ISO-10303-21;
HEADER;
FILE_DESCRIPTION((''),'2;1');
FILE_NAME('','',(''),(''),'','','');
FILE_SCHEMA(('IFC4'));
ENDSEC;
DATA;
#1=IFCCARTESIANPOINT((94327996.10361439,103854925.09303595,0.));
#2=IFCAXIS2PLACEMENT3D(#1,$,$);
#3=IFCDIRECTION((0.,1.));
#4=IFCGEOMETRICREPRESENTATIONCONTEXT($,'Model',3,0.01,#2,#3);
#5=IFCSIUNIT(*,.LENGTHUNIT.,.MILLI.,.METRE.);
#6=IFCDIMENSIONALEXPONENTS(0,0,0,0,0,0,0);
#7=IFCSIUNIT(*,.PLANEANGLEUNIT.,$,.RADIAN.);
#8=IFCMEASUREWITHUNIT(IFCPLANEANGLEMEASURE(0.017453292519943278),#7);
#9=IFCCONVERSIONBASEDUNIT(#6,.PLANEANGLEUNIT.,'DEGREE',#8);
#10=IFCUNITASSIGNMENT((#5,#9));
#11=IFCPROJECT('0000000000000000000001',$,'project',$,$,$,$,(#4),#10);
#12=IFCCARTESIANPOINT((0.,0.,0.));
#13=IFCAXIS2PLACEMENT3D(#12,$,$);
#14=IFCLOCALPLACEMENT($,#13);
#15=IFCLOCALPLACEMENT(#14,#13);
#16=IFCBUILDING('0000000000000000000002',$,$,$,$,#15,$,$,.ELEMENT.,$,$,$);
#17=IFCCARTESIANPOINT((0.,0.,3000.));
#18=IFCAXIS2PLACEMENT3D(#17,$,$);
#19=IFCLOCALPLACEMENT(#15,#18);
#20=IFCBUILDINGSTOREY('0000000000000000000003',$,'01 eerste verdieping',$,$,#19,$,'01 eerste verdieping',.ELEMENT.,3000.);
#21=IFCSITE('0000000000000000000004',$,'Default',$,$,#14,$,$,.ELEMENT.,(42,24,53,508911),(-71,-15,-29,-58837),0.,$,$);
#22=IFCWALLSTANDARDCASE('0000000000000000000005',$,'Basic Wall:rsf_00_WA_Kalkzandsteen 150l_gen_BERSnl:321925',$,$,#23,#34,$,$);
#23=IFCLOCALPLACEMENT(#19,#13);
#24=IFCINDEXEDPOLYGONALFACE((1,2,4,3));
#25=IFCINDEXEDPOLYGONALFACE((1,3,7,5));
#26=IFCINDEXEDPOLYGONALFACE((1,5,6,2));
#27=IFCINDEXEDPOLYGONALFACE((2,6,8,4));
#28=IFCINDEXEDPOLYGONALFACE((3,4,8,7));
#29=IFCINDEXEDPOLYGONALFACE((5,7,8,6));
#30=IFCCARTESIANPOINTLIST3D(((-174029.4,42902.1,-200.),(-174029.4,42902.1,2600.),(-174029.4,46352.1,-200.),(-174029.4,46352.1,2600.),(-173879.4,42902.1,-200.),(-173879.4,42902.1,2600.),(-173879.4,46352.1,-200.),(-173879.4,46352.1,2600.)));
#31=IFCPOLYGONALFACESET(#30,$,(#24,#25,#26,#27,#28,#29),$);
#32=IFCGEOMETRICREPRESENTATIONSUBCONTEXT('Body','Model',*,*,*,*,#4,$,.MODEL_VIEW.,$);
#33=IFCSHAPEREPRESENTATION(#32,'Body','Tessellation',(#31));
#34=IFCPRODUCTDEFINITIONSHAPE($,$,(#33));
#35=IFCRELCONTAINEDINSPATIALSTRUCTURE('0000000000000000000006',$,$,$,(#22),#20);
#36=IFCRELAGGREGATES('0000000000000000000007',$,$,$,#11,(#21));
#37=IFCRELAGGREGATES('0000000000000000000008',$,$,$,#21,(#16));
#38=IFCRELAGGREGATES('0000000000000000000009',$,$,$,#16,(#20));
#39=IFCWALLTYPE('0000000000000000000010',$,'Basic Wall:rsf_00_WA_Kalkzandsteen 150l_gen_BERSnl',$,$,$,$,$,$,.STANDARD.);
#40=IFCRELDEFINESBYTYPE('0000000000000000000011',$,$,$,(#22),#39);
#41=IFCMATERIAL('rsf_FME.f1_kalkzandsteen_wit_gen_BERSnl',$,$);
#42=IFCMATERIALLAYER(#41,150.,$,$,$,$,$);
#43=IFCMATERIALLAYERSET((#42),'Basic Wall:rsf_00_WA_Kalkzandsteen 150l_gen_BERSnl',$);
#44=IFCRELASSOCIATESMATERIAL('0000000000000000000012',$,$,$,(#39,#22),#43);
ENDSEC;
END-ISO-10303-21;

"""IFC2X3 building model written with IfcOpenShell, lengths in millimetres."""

from ifc_helpers import new_model, entity, si_unit, converted_unit, direction, frame, frame_2d, origin, place, context, subcontext, project, spatial, polyline, rectangle, extrude, clip, bounded_halfspace, material, layer, layer_set, layer_usage, type_object, element, save


model = new_model("IFC2X3")

# Units and contexts
model_context = context("Model", 3, precision=0.01, world=frame((94327996.10361439, 103854925.09303595, 0.0)), true_north=direction((0.0, 1.0)))
body_context = subcontext(model_context, "Body", "Model", "MODEL_VIEW")
ifc_project = project(units=[si_unit("LENGTHUNIT", "METRE", prefix="MILLI"), converted_unit("PLANEANGLEUNIT", "DEGREE", entity("IfcPlaneAngleMeasure", 0.017453292519943278), si_unit("PLANEANGLEUNIT", "RADIAN"), dimensions=[0, 0, 0, 0, 0, 0, 0])], contexts=[model_context])

# Site, building, storey
site_placement = place(None, origin())
site = spatial("IfcSite", under=ifc_project, at=site_placement, Name="Default", CompositionType="ELEMENT", RefLatitude=(42, 24, 53, 508911), RefLongitude=(-71, -15, -29, -58837), RefElevation=0.0)
building_placement = place(site_placement, origin())
building = spatial("IfcBuilding", under=site, at=building_placement, CompositionType="ELEMENT")
storey_placement = place(building_placement, frame((0.0, 0.0, 3000.0)))
storey = spatial("IfcBuildingStorey", under=building, at=storey_placement, Name="01 eerste verdieping", LongName="01 eerste verdieping", CompositionType="ELEMENT", Elevation=3000.0)

# Shared definitions
ifc_material = material(Name="rsf_FME.f1_kalkzandsteen_wit_gen_BERSnl")
ifc_layer = layer(ifc_material, 150.0)
ifc_layer_set = layer_set([ifc_layer], Name="Basic Wall:rsf_00_WA_Kalkzandsteen 150l_gen_BERSnl")
wall_type = type_object("IfcWallType", Name="Basic Wall:rsf_00_WA_Kalkzandsteen 150l_gen_BERSnl", PredefinedType="STANDARD", material=ifc_layer_set)

# Wall
ifc_layer_usage_1 = layer_usage(ifc_layer_set, "AXIS2", "POSITIVE", -75.0)
wall_1_placement = place(storey_placement, frame((-173954.4, 42902.1, -200.0), z_axis=(0.0, 0.0, 1.0), x_axis=(0.0, 1.0, 0.0)))
element("IfcWallStandardCase", 1, at=wall_1_placement, inside=storey, type_object=wall_type, material=ifc_layer_usage_1, Name="Basic Wall:rsf_00_WA_Kalkzandsteen 150l_gen_BERSnl:321925", context=body_context, shape_type="Clipping", body=[
    clip(extrude(rectangle(XDim=3450.0, YDim=150.0, at=frame_2d((1725.0, 0.0), x_axis=(-1.0, 0.0))), origin(), (0.0, 0.0, 1.0), 2800.0), bounded_halfspace(frame((0.0, -75.0, 2800.0), z_axis=(0.0, 0.0, -1.0), x_axis=(1.0, 0.0, 0.0)), True, frame((0.0, -75.0, 2800.0)), polyline([(0.0, 0.0), (3450.0, 0.0), (3450.0, 150.0), (0.0, 150.0), (0.0, 0.0)]))),
])

save(model, "model.ifc")
